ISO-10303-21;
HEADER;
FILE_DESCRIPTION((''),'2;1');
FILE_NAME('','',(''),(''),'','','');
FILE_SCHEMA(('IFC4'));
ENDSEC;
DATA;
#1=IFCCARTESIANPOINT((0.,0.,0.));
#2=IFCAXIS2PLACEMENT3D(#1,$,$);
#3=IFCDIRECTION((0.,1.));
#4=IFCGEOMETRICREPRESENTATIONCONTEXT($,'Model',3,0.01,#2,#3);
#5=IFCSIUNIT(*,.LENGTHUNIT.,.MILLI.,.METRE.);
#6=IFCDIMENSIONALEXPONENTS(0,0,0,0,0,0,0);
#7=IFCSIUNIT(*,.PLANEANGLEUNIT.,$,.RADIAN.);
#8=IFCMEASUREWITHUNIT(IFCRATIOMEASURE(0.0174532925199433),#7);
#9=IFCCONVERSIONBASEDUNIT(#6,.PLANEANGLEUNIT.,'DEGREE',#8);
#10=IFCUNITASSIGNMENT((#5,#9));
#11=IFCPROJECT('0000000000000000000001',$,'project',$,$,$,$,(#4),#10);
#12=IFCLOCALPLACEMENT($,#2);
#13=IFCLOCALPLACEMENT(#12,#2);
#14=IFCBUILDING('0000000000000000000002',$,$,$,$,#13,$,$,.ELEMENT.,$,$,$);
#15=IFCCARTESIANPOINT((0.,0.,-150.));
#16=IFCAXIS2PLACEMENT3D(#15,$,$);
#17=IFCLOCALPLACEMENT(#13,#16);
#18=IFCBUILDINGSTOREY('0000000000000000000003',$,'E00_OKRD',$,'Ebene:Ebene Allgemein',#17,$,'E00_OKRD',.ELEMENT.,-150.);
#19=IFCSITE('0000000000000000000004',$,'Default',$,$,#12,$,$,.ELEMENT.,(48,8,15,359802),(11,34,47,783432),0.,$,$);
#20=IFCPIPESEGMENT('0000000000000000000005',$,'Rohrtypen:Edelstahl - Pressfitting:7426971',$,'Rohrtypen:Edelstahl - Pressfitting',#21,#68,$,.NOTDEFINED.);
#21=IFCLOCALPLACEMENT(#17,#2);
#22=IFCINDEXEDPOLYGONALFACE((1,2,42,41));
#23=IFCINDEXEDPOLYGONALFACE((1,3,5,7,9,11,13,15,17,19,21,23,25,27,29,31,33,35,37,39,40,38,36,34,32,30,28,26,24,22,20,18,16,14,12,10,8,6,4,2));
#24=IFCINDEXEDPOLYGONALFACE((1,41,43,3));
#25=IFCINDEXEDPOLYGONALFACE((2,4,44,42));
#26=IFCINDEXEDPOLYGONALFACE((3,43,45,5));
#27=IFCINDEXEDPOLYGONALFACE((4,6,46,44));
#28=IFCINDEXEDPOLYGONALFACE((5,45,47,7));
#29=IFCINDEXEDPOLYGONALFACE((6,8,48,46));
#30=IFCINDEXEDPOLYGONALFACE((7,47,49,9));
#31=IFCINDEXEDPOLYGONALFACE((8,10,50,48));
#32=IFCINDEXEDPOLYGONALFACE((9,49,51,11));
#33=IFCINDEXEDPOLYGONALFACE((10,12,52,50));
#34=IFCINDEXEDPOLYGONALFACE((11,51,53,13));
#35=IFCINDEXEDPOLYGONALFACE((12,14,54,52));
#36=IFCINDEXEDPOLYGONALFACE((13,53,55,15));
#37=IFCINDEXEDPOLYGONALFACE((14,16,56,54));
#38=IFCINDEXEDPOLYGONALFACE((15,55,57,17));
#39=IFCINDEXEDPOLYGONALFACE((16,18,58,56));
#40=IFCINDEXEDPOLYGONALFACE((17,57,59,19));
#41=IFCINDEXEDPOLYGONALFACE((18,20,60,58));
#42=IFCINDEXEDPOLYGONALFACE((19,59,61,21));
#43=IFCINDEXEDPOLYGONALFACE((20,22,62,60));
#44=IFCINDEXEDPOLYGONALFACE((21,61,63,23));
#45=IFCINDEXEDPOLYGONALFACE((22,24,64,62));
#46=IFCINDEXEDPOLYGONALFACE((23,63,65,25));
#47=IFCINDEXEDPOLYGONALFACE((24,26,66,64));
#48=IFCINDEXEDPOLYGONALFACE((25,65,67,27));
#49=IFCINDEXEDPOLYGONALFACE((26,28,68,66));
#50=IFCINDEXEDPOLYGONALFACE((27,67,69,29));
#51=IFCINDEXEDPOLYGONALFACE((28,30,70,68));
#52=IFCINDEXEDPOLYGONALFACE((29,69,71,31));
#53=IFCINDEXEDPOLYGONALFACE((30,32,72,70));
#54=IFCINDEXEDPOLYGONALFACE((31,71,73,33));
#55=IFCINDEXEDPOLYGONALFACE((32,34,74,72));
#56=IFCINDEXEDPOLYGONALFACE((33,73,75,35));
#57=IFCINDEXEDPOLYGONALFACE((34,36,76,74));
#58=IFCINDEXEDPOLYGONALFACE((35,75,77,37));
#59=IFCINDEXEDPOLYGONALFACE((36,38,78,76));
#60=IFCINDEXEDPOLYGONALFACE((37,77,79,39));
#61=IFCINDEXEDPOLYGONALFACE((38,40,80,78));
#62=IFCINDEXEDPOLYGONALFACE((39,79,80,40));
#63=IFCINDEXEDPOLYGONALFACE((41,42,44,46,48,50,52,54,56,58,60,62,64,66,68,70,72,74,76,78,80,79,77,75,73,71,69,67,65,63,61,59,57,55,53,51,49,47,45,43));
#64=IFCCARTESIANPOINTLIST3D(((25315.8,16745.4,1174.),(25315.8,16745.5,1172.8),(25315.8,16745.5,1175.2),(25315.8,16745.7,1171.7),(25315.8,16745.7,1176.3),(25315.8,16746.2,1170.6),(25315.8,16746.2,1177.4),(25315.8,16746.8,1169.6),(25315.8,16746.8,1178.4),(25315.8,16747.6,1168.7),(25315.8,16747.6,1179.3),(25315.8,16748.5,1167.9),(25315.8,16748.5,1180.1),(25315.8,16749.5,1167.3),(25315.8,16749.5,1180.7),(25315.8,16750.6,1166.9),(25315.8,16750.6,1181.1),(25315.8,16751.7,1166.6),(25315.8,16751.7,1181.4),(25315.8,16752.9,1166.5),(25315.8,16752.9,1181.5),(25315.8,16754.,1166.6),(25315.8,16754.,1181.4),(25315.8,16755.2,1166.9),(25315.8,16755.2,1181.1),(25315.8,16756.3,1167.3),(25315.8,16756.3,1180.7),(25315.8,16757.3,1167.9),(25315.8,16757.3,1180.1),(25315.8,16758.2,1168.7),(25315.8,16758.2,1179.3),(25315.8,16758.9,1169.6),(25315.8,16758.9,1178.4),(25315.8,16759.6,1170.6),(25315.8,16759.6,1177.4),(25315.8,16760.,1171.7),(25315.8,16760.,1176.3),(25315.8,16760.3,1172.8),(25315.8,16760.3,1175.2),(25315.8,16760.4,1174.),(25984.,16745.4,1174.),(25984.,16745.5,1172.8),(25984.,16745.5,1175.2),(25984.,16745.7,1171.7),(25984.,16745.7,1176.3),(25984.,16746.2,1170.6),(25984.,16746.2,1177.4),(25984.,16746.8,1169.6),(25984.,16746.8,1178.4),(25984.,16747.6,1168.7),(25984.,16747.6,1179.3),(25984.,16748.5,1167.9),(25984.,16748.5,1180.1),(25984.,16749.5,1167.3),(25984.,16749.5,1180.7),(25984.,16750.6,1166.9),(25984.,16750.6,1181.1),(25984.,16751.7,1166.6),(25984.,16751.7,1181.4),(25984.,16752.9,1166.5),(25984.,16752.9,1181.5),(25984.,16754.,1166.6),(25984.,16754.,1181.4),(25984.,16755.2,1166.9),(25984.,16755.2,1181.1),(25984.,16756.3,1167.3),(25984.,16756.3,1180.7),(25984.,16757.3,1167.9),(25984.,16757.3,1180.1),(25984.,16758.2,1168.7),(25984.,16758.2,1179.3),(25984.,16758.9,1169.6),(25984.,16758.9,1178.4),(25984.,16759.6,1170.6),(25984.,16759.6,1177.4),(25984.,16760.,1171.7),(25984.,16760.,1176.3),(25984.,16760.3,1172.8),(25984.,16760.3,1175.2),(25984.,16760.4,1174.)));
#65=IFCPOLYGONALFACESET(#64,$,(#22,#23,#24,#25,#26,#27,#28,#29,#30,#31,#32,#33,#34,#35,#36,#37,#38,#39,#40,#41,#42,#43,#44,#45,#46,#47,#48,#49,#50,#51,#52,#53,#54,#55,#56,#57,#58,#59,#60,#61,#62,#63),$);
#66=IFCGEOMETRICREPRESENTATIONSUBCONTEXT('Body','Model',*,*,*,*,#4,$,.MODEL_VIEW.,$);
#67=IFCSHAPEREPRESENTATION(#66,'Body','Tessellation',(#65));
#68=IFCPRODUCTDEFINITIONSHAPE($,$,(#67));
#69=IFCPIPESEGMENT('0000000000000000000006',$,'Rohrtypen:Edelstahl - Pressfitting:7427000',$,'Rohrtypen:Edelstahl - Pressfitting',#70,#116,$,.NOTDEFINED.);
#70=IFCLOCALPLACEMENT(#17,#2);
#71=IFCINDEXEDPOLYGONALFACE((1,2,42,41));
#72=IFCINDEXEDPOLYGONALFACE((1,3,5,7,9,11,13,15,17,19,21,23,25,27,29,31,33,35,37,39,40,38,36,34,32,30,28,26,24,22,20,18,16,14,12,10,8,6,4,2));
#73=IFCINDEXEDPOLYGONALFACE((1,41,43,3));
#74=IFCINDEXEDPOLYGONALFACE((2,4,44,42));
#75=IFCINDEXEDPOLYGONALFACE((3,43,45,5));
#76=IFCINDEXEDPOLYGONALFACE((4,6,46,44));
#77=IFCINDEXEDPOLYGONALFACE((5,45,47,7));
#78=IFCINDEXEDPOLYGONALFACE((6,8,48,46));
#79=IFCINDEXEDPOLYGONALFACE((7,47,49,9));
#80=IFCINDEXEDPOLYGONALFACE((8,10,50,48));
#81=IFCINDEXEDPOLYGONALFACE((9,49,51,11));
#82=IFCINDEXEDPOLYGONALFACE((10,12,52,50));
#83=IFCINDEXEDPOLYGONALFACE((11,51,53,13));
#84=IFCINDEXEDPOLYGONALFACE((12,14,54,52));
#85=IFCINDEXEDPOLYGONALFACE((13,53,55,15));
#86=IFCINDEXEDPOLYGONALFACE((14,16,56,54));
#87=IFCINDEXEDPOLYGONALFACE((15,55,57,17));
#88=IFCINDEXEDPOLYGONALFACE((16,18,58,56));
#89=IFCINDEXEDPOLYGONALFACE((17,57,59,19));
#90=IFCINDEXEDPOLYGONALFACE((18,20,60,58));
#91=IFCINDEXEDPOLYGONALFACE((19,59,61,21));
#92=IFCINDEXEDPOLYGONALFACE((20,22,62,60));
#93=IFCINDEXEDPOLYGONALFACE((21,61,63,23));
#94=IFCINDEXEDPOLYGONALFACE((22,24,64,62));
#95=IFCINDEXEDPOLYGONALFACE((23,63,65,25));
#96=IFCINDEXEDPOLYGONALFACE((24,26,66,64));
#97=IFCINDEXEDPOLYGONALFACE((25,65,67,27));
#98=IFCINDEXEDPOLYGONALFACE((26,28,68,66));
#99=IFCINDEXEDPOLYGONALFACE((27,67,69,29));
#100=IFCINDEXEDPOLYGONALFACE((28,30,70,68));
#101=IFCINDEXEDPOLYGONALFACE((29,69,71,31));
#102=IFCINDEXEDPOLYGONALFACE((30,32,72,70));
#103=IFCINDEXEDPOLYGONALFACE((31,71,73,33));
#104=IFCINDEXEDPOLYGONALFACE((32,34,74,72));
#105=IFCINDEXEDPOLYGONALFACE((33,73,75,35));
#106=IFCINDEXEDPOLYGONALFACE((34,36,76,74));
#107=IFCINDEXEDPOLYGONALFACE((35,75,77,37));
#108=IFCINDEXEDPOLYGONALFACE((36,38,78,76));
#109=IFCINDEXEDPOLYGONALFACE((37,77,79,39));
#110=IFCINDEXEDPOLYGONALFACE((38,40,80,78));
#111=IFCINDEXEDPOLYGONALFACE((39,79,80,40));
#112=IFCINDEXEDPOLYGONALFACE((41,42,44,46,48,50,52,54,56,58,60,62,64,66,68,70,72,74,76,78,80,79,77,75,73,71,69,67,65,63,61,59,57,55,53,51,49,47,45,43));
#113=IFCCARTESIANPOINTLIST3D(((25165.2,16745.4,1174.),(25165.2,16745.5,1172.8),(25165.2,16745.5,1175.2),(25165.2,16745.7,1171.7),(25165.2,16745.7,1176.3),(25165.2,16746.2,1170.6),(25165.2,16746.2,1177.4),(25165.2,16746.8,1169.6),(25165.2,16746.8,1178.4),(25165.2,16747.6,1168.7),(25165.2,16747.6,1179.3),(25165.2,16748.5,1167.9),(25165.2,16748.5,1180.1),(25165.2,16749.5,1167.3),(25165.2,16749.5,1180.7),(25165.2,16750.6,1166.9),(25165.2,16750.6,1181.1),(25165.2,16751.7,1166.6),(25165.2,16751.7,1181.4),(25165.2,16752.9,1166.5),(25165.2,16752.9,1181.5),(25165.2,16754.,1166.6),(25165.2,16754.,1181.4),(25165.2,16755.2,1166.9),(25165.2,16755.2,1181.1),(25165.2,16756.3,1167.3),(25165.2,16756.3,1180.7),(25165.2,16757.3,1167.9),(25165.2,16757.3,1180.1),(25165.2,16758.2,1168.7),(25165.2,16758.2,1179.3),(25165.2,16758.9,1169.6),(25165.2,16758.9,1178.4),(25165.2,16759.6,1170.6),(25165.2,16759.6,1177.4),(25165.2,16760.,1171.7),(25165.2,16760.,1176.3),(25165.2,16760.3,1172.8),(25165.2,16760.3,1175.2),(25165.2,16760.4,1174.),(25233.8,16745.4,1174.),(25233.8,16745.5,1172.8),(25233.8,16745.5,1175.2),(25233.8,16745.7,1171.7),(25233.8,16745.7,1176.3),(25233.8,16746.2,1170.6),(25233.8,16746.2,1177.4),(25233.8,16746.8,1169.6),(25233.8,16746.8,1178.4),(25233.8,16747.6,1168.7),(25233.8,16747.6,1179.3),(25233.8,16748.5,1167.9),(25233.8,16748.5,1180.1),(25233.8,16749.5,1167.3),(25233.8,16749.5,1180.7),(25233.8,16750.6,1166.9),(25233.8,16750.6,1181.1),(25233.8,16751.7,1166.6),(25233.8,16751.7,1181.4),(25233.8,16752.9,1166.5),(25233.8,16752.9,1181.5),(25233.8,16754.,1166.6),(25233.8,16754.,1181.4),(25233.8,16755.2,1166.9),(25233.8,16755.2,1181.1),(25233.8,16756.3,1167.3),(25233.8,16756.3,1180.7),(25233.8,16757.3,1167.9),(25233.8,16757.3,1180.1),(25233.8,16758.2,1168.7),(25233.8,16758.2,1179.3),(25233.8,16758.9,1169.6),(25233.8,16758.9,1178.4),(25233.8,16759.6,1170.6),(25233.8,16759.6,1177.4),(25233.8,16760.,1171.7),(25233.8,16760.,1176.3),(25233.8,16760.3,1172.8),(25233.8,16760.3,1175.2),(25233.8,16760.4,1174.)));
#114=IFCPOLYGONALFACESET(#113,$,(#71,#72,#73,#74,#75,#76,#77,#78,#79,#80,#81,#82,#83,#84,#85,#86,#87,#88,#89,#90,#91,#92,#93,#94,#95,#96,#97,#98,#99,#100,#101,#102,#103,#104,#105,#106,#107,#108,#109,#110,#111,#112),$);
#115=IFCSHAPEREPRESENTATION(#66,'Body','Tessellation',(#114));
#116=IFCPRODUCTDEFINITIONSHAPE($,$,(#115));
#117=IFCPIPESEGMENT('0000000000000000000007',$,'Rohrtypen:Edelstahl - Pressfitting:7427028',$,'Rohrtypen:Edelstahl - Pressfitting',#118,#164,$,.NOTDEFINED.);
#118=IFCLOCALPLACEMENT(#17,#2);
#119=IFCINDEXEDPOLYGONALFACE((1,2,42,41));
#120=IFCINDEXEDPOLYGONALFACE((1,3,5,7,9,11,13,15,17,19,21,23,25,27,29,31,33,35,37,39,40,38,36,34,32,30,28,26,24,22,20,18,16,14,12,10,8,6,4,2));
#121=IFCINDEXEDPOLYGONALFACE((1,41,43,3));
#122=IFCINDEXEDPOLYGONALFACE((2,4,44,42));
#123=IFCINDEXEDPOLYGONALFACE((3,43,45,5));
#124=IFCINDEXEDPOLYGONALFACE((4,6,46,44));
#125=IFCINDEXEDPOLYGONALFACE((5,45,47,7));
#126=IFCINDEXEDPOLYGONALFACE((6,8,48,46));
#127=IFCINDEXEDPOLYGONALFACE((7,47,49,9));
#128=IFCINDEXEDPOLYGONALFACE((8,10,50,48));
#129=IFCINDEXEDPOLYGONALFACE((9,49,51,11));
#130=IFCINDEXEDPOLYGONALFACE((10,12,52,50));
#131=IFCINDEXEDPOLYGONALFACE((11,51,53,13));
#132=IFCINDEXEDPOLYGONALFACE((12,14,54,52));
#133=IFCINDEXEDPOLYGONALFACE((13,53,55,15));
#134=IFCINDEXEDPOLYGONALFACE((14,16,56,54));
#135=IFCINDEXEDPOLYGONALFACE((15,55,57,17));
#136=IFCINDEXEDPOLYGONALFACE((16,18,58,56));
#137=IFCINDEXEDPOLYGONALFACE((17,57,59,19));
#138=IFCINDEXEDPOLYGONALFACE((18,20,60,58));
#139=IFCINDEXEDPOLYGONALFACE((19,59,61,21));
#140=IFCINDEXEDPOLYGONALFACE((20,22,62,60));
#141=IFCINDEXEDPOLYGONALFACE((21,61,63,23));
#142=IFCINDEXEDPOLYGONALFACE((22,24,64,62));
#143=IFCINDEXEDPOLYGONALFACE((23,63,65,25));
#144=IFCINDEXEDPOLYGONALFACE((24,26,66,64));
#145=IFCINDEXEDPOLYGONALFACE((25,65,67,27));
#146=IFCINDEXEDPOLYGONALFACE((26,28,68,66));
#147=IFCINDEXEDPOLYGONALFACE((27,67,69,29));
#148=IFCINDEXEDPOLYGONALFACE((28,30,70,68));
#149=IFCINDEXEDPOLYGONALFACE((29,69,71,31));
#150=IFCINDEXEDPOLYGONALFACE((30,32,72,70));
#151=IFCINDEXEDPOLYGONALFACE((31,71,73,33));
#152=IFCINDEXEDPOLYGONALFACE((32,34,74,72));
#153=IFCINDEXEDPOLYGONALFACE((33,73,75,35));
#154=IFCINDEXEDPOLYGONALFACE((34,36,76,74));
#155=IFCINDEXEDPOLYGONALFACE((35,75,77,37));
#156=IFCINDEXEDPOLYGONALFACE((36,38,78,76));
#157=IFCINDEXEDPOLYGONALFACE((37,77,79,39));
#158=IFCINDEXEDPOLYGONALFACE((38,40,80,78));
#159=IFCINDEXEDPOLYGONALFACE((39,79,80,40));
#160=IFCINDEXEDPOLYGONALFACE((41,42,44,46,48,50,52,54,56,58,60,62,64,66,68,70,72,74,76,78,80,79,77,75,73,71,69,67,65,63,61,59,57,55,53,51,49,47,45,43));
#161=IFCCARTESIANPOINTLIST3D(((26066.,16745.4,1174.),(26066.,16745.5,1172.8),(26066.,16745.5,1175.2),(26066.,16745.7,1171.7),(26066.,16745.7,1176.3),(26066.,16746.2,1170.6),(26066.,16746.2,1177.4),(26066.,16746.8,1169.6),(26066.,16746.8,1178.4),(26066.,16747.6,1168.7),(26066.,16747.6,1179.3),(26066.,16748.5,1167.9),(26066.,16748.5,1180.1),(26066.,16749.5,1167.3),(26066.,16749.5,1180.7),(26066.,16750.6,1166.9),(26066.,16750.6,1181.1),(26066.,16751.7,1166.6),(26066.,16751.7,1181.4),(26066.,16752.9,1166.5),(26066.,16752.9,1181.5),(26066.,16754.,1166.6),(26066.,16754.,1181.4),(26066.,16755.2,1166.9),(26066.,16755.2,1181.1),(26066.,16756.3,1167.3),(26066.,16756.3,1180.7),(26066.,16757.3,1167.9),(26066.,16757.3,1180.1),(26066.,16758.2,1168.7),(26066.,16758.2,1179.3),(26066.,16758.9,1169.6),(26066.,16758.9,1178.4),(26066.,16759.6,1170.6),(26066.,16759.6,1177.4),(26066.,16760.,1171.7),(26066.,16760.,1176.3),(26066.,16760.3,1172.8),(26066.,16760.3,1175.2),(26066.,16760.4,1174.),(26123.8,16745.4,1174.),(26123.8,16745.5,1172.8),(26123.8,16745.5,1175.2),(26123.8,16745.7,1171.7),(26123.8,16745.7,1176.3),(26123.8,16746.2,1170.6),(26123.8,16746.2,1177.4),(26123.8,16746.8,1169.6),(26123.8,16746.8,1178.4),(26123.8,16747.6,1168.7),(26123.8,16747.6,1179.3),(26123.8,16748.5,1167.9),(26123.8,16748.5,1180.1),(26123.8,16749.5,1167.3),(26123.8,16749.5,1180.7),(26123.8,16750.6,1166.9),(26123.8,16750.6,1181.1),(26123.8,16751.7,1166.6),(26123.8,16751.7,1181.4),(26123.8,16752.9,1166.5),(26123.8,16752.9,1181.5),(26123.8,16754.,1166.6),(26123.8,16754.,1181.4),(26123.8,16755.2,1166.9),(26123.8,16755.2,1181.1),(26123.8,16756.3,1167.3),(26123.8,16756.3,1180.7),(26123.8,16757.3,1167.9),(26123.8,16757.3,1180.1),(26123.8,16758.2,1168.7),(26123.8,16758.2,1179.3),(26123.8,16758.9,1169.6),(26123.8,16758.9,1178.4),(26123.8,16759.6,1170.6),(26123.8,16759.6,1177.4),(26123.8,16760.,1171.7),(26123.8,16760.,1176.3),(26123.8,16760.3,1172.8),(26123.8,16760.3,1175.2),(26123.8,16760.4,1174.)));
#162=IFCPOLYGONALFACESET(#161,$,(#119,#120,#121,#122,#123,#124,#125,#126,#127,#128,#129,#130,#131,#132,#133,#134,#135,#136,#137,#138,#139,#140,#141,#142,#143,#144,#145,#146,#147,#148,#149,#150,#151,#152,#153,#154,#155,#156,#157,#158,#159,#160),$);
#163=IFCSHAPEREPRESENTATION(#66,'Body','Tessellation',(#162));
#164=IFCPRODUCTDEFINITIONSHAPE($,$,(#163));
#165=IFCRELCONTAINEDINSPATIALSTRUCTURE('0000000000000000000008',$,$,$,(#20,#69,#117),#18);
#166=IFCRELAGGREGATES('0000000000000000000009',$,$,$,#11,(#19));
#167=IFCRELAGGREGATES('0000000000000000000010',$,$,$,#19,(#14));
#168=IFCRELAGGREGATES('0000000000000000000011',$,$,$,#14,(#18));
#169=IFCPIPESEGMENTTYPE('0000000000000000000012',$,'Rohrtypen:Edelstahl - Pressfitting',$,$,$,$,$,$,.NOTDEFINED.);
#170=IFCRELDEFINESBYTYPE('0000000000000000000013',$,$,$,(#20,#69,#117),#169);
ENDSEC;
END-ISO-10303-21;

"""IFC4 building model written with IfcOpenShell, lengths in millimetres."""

from ifc_helpers import new_model, entity, si_unit, converted_unit, direction, frame, origin, place, context, subcontext, project, spatial, indexed_curve, outline, extrude, type_object, element, save


model = new_model("IFC4")

# Units and contexts
model_context = context("Model", 3, precision=0.01, world=origin(), true_north=direction((0.0, 1.0)))
body_context = subcontext(model_context, "Body", "Model", "MODEL_VIEW")
ifc_project = project(units=[si_unit("LENGTHUNIT", "METRE", prefix="MILLI"), converted_unit("PLANEANGLEUNIT", "DEGREE", entity("IfcRatioMeasure", 0.0174532925199433), si_unit("PLANEANGLEUNIT", "RADIAN"), dimensions=[0, 0, 0, 0, 0, 0, 0])], contexts=[model_context])

# Site, building, storey
site_placement = place(None, origin())
site = spatial("IfcSite", under=ifc_project, at=site_placement, Name="Default", CompositionType="ELEMENT", RefLatitude=(48, 8, 15, 359802), RefLongitude=(11, 34, 47, 783432), RefElevation=0.0)
building_placement = place(site_placement, origin())
building = spatial("IfcBuilding", under=site, at=building_placement, CompositionType="ELEMENT")
storey_placement = place(building_placement, frame((0.0, 0.0, -150.0)))
storey = spatial("IfcBuildingStorey", under=building, at=storey_placement, Name="E00_OKRD", ObjectType="Ebene:Ebene Allgemein", LongName="E00_OKRD", CompositionType="ELEMENT", Elevation=-150.0)

# Pipe segments
pipe_segment_type_1 = type_object("IfcPipeSegmentType", Name="Rohrtypen:Edelstahl - Pressfitting", PredefinedType="NOTDEFINED")
pipe_segment_1_placement = place(storey_placement, origin())
element("IfcPipeSegment", 1, at=pipe_segment_1_placement, inside=storey, type_object=pipe_segment_type_1, Name="Rohrtypen:Edelstahl - Pressfitting:7426971", ObjectType="Rohrtypen:Edelstahl - Pressfitting", PredefinedType="NOTDEFINED", context=body_context, shape_type="SweptSolid", body=[
    extrude(outline(indexed_curve([(7.5, 0.0), (7.4, 1.2), (7.1, 2.3), (6.7, 3.4), (6.1, 4.4), (5.3, 5.3), (4.4, 6.1), (3.4, 6.7), (2.3, 7.1), (1.2, 7.4), (0.0, 7.5), (-1.2, 7.4), (-2.3, 7.1), (-3.4, 6.7), (-4.4, 6.1), (-5.3, 5.3), (-6.1, 4.4), (-6.7, 3.4), (-7.1, 2.3), (-7.4, 1.2), (-7.5, 0.0), (-7.4, -1.2), (-7.1, -2.3), (-6.7, -3.4), (-6.1, -4.4), (-5.3, -5.3), (-4.4, -6.1), (-3.4, -6.7), (-2.3, -7.1), (-1.2, -7.4), (0.0, -7.5), (1.2, -7.4), (2.3, -7.1), (3.4, -6.7), (4.4, -6.1), (5.3, -5.3), (6.1, -4.4), (6.7, -3.4), (7.1, -2.3), (7.4, -1.2), (7.5, 0.0)], self_intersect=False)), frame((25315.8, 16752.9, 1174.0), z_axis=(1.0, 0.0, 0.00001), x_axis=(0.0, 1.0, 0.0)), (0.0, 0.0, 1.0), 668.1),
])
pipe_segment_2_placement = place(storey_placement, origin())
element("IfcPipeSegment", 2, at=pipe_segment_2_placement, inside=storey, type_object=pipe_segment_type_1, Name="Rohrtypen:Edelstahl - Pressfitting:7427000", ObjectType="Rohrtypen:Edelstahl - Pressfitting", PredefinedType="NOTDEFINED", context=body_context, shape_type="SweptSolid", body=[
    extrude(outline(indexed_curve([(7.5, 0.0), (7.4, 1.2), (7.1, 2.3), (6.7, 3.4), (6.1, 4.4), (5.3, 5.3), (4.4, 6.1), (3.4, 6.7), (2.3, 7.1), (1.2, 7.4), (0.0, 7.5), (-1.2, 7.4), (-2.3, 7.1), (-3.4, 6.7), (-4.4, 6.1), (-5.3, 5.3), (-6.1, 4.4), (-6.7, 3.4), (-7.1, 2.3), (-7.4, 1.2), (-7.5, 0.0), (-7.4, -1.2), (-7.1, -2.3), (-6.7, -3.4), (-6.1, -4.4), (-5.3, -5.3), (-4.4, -6.1), (-3.4, -6.7), (-2.3, -7.1), (-1.2, -7.4), (0.0, -7.5), (1.2, -7.4), (2.3, -7.1), (3.4, -6.7), (4.4, -6.1), (5.3, -5.3), (6.1, -4.4), (6.7, -3.4), (7.1, -2.3), (7.4, -1.2), (7.5, 0.0)], self_intersect=False)), frame((25165.2, 16752.9, 1174.0), z_axis=(1.0, 0.0, 0.00001), x_axis=(0.0, 1.0, 0.0)), (0.0, 0.0, 1.0), 68.6),
])
pipe_segment_3_placement = place(storey_placement, origin())
element("IfcPipeSegment", 3, at=pipe_segment_3_placement, inside=storey, type_object=pipe_segment_type_1, Name="Rohrtypen:Edelstahl - Pressfitting:7427028", ObjectType="Rohrtypen:Edelstahl - Pressfitting", PredefinedType="NOTDEFINED", context=body_context, shape_type="SweptSolid", body=[
    extrude(outline(indexed_curve([(7.5, 0.0), (7.4, 1.2), (7.1, 2.3), (6.7, 3.4), (6.1, 4.4), (5.3, 5.3), (4.4, 6.1), (3.4, 6.7), (2.3, 7.1), (1.2, 7.4), (0.0, 7.5), (-1.2, 7.4), (-2.3, 7.1), (-3.4, 6.7), (-4.4, 6.1), (-5.3, 5.3), (-6.1, 4.4), (-6.7, 3.4), (-7.1, 2.3), (-7.4, 1.2), (-7.5, 0.0), (-7.4, -1.2), (-7.1, -2.3), (-6.7, -3.4), (-6.1, -4.4), (-5.3, -5.3), (-4.4, -6.1), (-3.4, -6.7), (-2.3, -7.1), (-1.2, -7.4), (0.0, -7.5), (1.2, -7.4), (2.3, -7.1), (3.4, -6.7), (4.4, -6.1), (5.3, -5.3), (6.1, -4.4), (6.7, -3.4), (7.1, -2.3), (7.4, -1.2), (7.5, 0.0)], self_intersect=False)), frame((26066.0, 16752.9, 1174.0), z_axis=(1.0, 0.0, 0.0), x_axis=(0.0, 1.0, 0.0)), (0.0, 0.0, 1.0), 57.9),
])

save(model, "model.ifc")
